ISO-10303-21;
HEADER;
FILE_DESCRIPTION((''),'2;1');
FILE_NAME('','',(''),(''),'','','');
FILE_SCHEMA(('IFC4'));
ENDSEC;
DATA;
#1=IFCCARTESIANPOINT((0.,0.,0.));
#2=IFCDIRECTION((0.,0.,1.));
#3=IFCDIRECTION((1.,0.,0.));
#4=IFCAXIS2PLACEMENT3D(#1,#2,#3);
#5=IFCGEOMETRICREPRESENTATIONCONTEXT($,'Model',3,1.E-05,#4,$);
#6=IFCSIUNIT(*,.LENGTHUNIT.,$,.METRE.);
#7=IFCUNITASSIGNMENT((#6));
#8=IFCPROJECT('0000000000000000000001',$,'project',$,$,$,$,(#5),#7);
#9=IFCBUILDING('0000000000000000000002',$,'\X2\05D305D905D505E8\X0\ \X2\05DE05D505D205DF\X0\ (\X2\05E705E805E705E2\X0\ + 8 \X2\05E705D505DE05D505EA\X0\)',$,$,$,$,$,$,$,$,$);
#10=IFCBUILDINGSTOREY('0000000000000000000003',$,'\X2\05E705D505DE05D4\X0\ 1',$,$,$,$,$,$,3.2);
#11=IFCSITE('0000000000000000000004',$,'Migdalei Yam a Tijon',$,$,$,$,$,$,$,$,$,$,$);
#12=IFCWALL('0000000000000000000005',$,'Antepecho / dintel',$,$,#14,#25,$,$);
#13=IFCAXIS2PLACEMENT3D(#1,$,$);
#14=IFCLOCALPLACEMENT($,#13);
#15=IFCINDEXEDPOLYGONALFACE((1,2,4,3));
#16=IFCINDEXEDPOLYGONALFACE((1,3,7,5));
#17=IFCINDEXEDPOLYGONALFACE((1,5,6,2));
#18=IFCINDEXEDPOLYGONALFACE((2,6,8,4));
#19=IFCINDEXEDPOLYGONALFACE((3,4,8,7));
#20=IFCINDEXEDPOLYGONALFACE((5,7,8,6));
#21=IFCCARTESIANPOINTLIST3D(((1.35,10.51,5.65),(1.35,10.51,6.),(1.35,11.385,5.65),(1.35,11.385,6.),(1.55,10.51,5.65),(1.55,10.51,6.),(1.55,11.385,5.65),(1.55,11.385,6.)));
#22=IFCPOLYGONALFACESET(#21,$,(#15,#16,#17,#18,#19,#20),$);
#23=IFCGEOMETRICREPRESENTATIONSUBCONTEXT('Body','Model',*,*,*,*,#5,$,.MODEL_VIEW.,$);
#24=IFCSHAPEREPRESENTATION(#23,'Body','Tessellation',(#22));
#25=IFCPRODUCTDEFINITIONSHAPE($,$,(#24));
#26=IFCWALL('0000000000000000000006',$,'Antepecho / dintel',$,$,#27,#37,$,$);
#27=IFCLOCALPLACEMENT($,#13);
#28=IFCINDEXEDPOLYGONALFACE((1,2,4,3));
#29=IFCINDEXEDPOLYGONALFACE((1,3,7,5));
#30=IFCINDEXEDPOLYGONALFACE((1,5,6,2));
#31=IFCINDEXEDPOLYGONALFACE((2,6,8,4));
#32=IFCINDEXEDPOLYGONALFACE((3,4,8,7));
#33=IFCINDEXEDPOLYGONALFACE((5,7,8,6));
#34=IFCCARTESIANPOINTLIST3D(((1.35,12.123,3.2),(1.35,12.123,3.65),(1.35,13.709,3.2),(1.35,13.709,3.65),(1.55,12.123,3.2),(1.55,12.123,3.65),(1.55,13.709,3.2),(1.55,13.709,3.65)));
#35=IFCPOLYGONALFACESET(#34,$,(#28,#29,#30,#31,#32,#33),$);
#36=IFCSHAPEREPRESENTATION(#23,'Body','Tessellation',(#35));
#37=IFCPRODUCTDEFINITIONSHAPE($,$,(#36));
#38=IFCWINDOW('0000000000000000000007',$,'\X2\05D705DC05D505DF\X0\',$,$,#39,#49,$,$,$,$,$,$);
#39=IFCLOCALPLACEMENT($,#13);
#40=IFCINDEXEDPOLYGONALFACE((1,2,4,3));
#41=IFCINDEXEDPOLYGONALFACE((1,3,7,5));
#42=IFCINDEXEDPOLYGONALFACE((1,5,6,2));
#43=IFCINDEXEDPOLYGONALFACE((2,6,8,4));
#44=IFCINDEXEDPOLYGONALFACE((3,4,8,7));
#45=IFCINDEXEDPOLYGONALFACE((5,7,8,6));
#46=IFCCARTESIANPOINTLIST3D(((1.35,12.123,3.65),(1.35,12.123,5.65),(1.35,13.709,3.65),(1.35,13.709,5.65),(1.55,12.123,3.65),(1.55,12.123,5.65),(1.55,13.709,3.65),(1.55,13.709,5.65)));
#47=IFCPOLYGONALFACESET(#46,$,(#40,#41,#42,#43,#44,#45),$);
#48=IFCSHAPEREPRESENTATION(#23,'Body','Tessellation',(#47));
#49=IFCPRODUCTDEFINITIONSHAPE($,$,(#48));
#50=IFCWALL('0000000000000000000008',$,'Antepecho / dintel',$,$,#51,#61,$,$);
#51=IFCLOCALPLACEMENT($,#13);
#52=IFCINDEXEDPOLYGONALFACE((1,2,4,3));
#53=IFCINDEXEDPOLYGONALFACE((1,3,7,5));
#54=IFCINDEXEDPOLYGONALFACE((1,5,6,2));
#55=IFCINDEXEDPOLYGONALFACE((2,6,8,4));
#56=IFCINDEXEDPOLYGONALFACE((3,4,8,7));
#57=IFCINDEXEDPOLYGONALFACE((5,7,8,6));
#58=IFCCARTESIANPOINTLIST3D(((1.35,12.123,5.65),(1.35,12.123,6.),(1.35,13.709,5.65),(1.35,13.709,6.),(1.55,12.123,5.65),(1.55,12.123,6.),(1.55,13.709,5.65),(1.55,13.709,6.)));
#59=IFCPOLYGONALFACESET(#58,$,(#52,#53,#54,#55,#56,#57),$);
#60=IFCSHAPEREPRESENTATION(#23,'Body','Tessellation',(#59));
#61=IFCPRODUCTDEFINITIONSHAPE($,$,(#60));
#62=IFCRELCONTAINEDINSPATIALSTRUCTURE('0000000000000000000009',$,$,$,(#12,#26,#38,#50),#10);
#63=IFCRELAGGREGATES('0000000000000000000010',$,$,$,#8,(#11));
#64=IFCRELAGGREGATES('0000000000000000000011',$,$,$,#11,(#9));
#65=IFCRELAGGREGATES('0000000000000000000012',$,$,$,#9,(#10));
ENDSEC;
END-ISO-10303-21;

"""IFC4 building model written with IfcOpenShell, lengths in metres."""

from ifc_helpers import new_model, si_unit, frame, origin_with_axes, context, subcontext, project, spatial, line, indexed_curve, outline, extrude, element, save


model = new_model("IFC4")

# Units and contexts
model_context = context("Model", 3, precision=1e-05, world=origin_with_axes())
body_context = subcontext(model_context, "Body", "Model", "MODEL_VIEW")
ifc_project = project(units=[si_unit("LENGTHUNIT", "METRE")], contexts=[model_context])

# Site, building, storey
site = spatial("IfcSite", under=ifc_project, Name="Migdalei Yam a Tijon")
building = spatial("IfcBuilding", under=site, Name="דיור מוגן (קרקע + 8 קומות)")
storey = spatial("IfcBuildingStorey", under=building, Name="קומה 1", Elevation=3.2)

# Walls
element("IfcWall", 1, inside=storey, Name="Antepecho / dintel", context=body_context, shape_type="SweptSolid", body=[
    extrude(outline(indexed_curve([(0.0, 0.0), (0.2, 0.0), (0.2, 0.875), (0.0, 0.875)], segments=[line(1, 2, 3, 4, 1)])), frame((1.35, 10.51, 5.65), z_axis=(0.0, 0.0, 1.0), x_axis=(1.0, 0.0, 0.0)), (0.0, 0.0, 1.0), 0.35),
])
element("IfcWall", 2, inside=storey, Name="Antepecho / dintel", context=body_context, shape_type="SweptSolid", body=[
    extrude(outline(indexed_curve([(0.0, 0.0), (0.2, 0.0), (0.2, 1.586), (0.0, 1.586)], segments=[line(1, 2, 3, 4, 1)])), frame((1.35, 12.123, 3.2), z_axis=(0.0, 0.0, 1.0), x_axis=(1.0, 0.0, 0.0)), (0.0, 0.0, 1.0), 0.45),
])

# Window
element("IfcWindow", 3, inside=storey, Name="חלון", context=body_context, shape_type="SweptSolid", body=[
    extrude(outline(indexed_curve([(0.0, 0.0), (0.2, 0.0), (0.2, 1.586), (0.0, 1.586)], segments=[line(1, 2, 3, 4, 1)])), frame((1.35, 12.123, 3.65), z_axis=(0.0, 0.0, 1.0), x_axis=(1.0, 0.0, 0.0)), (0.0, 0.0, 1.0), 2.0),
])

# Wall
element("IfcWall", 4, inside=storey, Name="Antepecho / dintel", context=body_context, shape_type="SweptSolid", body=[
    extrude(outline(indexed_curve([(0.0, 0.0), (0.2, 0.0), (0.2, 1.586), (0.0, 1.586)], segments=[line(1, 2, 3, 4, 1)])), frame((1.35, 12.123, 5.65), z_axis=(0.0, 0.0, 1.0), x_axis=(1.0, 0.0, 0.0)), (0.0, 0.0, 1.0), 0.35),
])

save(model, "model.ifc")
